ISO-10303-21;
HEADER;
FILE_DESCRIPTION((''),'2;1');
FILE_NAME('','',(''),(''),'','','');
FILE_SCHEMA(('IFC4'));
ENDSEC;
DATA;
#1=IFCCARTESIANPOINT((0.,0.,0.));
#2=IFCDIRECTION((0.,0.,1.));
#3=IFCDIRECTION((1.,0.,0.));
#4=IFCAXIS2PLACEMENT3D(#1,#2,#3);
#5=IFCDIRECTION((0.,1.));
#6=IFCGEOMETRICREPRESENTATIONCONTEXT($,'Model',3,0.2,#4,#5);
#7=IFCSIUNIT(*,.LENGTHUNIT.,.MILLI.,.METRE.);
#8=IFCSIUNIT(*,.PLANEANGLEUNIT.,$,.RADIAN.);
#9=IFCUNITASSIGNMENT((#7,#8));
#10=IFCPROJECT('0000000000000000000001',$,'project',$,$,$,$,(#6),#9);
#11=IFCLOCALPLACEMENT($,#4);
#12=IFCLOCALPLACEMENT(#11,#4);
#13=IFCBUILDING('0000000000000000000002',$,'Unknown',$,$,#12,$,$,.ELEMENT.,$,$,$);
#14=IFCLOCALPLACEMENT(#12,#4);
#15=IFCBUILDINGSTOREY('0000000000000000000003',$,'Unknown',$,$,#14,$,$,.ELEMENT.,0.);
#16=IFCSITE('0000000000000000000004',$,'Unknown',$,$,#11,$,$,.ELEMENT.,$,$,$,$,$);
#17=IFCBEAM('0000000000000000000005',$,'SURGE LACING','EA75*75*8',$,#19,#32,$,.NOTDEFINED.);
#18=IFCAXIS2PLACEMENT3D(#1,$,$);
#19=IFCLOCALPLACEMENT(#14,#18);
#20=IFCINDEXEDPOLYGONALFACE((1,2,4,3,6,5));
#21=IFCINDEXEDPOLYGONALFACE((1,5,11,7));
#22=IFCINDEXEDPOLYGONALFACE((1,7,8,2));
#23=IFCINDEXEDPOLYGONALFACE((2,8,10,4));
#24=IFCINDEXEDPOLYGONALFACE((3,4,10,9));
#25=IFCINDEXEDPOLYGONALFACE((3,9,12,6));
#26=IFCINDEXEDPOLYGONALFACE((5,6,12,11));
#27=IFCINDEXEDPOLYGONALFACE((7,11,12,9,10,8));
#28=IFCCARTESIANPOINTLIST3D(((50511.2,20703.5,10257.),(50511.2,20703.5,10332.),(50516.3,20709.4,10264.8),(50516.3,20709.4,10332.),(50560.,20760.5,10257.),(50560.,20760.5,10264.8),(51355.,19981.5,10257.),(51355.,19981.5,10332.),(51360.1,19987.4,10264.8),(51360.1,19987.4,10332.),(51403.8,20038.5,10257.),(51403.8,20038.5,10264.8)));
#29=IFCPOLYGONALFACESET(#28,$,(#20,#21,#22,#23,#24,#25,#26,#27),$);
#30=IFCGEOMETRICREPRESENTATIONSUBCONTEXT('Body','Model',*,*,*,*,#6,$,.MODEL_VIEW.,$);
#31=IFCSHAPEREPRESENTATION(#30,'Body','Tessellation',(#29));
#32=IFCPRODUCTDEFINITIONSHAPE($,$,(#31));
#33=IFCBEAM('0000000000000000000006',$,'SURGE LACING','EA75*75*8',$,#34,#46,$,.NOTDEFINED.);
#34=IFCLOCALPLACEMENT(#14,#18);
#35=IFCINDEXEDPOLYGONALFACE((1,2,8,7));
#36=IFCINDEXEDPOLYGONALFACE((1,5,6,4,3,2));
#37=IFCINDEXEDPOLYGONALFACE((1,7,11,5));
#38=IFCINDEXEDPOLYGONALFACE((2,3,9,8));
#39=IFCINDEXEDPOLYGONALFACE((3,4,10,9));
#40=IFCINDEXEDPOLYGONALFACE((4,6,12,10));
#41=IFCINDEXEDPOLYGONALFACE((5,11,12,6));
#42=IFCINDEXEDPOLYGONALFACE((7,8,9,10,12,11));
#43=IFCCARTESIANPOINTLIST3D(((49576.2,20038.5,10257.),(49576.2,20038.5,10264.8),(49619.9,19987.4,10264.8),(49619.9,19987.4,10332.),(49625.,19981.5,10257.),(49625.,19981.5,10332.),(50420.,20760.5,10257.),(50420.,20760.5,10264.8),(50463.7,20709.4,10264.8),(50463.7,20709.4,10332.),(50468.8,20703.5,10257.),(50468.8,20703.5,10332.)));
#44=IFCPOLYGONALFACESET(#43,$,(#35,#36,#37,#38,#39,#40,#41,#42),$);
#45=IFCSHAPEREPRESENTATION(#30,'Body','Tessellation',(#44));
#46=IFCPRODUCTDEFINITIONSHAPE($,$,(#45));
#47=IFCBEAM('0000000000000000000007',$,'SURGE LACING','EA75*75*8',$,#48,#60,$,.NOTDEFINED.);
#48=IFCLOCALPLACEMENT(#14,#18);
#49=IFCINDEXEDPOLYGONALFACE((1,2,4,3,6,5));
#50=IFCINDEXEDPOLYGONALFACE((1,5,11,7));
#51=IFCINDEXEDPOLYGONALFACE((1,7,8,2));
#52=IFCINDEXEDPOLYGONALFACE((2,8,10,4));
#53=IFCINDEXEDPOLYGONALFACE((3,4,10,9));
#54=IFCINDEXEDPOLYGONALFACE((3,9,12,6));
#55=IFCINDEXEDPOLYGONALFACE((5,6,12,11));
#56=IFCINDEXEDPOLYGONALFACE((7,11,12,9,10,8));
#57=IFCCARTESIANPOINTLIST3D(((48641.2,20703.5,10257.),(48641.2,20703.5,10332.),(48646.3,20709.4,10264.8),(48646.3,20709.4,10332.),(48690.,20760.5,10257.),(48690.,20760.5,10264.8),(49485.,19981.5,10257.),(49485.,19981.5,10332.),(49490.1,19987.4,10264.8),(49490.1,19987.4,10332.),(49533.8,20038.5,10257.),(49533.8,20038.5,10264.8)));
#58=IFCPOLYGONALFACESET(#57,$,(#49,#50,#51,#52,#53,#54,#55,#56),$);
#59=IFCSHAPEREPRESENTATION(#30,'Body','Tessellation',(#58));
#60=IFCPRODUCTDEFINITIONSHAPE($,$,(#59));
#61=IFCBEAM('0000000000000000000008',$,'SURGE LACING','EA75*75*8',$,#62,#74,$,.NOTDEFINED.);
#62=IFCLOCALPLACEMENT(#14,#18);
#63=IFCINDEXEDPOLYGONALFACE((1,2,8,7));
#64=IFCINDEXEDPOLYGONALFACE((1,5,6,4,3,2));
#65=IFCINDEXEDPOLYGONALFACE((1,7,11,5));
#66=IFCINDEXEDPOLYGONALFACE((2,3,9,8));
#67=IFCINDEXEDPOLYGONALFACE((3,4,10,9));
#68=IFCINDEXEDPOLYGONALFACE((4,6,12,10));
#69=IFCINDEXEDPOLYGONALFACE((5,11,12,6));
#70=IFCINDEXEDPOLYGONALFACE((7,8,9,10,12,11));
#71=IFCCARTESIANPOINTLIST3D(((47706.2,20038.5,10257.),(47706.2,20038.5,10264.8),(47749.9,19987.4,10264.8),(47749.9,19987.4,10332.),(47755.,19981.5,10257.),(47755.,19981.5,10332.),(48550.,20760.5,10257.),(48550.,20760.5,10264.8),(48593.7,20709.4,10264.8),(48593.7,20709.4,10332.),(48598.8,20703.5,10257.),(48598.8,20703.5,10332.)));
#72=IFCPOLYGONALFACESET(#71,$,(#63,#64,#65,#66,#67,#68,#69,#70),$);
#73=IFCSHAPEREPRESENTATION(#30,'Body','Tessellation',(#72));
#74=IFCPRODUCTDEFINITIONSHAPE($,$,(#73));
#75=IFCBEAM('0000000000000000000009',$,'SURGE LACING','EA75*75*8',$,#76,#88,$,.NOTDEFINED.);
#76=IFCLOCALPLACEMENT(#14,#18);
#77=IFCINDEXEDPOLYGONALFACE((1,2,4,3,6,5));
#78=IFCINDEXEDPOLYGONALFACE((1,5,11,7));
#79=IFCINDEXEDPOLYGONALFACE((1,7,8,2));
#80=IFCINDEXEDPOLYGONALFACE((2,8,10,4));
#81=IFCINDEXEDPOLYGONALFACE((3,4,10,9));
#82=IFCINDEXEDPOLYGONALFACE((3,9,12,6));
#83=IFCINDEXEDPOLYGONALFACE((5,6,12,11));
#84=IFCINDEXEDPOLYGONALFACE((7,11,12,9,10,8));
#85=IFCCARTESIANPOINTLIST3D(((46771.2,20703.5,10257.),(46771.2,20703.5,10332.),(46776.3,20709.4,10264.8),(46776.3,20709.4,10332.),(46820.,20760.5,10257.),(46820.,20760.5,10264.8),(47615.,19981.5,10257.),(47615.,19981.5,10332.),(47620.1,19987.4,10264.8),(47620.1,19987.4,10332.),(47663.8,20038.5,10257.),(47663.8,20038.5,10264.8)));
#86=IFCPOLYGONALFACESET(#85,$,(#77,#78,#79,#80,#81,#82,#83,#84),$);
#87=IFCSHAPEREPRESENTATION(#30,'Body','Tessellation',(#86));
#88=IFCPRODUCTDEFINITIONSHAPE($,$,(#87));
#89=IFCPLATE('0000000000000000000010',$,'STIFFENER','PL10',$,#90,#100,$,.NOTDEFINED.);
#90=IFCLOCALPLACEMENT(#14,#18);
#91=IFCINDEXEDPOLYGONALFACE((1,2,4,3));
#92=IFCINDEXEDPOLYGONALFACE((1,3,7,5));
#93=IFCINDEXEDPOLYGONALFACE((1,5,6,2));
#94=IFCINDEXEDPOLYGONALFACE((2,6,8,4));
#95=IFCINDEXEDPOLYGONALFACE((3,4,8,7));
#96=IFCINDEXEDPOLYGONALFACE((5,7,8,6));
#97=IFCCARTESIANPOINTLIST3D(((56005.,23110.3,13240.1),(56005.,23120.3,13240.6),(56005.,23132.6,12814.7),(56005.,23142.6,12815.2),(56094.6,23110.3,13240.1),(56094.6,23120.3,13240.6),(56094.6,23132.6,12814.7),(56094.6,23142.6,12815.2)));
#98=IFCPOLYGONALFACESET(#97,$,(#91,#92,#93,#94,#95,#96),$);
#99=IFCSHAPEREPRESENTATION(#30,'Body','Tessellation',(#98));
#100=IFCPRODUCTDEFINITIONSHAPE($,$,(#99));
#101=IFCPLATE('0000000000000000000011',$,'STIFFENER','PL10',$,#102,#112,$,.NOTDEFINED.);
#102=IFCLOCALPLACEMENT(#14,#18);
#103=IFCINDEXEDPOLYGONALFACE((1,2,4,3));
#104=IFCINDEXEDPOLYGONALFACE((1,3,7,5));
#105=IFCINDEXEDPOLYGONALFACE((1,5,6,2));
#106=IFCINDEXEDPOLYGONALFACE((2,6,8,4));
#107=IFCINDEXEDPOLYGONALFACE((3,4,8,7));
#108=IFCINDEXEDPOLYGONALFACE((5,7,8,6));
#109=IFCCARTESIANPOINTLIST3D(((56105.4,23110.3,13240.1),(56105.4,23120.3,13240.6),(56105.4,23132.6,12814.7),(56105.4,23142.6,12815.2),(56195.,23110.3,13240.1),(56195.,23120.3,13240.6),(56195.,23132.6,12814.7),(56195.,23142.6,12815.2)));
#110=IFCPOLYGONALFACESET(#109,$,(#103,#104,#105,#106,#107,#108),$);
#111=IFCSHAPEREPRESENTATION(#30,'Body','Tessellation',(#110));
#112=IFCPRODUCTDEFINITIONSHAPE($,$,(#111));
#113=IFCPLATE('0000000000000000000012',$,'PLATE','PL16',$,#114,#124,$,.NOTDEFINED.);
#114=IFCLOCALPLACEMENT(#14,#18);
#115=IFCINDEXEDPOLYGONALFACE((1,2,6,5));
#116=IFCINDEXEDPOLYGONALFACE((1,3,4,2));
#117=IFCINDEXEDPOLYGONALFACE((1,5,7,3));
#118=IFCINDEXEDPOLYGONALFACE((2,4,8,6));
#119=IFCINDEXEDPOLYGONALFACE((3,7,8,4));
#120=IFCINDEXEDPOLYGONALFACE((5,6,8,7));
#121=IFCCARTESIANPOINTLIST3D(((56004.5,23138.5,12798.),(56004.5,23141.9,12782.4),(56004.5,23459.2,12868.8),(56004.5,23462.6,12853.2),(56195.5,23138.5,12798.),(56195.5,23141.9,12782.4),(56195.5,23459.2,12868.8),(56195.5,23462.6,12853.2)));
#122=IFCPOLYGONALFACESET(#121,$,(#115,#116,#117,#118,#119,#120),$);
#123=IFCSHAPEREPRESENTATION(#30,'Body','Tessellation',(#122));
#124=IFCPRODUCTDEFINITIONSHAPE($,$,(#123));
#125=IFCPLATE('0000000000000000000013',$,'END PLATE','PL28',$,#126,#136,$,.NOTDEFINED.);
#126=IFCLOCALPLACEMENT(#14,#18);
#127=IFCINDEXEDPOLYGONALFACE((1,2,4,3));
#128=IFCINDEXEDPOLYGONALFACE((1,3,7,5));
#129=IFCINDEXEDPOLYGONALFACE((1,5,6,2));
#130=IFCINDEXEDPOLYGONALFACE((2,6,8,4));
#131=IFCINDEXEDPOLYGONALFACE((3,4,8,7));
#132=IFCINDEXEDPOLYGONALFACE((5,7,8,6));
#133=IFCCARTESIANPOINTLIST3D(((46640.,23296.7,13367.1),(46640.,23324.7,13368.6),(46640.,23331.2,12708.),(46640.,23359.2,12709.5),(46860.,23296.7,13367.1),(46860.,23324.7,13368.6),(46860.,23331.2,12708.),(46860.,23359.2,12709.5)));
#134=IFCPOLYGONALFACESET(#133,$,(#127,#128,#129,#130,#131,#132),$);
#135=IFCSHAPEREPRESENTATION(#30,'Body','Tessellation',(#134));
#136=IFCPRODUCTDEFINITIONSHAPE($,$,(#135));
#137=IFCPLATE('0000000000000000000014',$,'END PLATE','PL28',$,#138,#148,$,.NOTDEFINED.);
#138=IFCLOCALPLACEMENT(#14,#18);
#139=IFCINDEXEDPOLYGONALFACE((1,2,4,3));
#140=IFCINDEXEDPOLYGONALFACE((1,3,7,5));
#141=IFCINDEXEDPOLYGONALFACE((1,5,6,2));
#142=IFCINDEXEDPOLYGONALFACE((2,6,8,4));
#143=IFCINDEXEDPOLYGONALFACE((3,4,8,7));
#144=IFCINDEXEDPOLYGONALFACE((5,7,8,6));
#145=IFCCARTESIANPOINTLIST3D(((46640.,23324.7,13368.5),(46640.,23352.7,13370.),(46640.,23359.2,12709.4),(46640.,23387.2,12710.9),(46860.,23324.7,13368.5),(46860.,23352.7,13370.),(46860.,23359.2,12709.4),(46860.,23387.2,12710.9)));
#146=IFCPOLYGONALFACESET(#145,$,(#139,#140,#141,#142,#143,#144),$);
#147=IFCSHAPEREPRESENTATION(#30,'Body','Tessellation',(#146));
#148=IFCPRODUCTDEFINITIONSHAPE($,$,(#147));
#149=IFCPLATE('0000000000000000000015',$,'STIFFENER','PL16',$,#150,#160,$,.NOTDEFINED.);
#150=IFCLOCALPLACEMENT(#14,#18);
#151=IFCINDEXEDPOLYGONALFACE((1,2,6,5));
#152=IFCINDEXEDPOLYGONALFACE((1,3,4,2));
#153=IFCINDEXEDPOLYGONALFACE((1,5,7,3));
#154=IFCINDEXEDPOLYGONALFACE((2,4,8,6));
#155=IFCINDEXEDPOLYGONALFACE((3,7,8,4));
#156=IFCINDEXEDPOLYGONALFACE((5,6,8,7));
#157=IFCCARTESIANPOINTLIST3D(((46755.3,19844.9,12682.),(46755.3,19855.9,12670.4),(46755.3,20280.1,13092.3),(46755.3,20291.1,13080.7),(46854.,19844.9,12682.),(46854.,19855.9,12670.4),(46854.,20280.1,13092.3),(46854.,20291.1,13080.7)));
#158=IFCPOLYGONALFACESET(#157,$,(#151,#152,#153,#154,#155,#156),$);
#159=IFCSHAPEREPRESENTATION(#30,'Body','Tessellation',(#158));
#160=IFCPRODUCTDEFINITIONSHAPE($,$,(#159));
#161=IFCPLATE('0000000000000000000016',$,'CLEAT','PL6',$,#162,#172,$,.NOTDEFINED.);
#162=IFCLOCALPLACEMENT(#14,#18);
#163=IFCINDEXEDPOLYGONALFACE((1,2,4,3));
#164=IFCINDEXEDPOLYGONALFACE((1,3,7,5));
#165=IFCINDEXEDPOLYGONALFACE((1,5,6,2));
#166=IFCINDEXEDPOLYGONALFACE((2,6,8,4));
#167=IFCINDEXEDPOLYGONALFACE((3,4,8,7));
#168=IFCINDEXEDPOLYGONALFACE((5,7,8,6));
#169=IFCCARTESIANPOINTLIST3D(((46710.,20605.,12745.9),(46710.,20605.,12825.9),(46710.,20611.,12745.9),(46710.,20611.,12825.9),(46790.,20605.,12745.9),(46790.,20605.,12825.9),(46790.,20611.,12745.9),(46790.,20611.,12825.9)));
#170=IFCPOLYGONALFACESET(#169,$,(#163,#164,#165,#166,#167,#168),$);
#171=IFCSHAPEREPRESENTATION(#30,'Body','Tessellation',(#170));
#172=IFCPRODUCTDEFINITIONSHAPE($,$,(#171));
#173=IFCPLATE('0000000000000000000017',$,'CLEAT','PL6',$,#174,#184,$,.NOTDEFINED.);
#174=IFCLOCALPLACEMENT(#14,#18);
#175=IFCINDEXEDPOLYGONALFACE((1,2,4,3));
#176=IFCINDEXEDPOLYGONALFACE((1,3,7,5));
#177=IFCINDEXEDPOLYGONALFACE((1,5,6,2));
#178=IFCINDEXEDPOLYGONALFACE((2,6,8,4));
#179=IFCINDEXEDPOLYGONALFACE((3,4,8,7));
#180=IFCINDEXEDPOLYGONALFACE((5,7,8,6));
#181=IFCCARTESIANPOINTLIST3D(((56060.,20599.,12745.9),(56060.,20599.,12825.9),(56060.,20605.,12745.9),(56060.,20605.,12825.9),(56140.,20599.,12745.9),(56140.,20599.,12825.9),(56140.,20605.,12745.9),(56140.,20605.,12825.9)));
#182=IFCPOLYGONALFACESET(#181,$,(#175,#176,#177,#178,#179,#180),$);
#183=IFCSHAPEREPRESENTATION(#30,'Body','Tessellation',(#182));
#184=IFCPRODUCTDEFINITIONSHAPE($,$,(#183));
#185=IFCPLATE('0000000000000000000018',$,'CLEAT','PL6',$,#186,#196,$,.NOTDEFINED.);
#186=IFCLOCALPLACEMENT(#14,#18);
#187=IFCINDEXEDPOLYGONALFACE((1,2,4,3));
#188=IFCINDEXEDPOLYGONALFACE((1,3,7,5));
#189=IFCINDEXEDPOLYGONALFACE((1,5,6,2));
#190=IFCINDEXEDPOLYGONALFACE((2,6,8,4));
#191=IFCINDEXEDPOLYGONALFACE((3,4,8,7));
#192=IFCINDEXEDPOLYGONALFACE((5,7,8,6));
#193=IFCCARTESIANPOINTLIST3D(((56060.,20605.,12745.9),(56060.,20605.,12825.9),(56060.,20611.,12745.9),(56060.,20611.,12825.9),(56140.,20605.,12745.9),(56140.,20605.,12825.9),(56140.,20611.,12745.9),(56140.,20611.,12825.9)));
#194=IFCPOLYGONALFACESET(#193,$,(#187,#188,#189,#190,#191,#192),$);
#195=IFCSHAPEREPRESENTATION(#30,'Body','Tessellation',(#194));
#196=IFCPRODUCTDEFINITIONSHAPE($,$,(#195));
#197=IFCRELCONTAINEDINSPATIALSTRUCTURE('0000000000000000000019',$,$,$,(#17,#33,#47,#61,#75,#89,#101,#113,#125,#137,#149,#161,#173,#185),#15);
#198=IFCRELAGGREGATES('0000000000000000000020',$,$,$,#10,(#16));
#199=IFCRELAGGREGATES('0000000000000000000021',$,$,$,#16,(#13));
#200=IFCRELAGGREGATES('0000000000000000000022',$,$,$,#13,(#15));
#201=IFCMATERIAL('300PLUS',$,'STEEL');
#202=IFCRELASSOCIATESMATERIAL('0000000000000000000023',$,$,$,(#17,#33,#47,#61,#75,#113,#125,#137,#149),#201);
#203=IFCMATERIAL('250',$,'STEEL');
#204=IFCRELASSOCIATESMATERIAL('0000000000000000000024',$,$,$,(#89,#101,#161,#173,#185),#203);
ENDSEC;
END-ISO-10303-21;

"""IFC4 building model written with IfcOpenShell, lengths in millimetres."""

from ifc_helpers import new_model, si_unit, direction, frame, origin_with_axes, place, context, subcontext, project, spatial, line, indexed_curve, outline, extrude, material, element, save


model = new_model("IFC4")

# Units and contexts
model_context = context("Model", 3, precision=0.2, world=origin_with_axes(), true_north=direction((0.0, 1.0)))
body_context = subcontext(model_context, "Body", "Model", "MODEL_VIEW")
ifc_project = project(units=[si_unit("LENGTHUNIT", "METRE", prefix="MILLI"), si_unit("PLANEANGLEUNIT", "RADIAN")], contexts=[model_context])

# Site, building, storey
site_placement = place(None, origin_with_axes())
site = spatial("IfcSite", under=ifc_project, at=site_placement, Name="Unknown", CompositionType="ELEMENT")
building_placement = place(site_placement, origin_with_axes())
building = spatial("IfcBuilding", under=site, at=building_placement, Name="Unknown", CompositionType="ELEMENT")
storey_placement = place(building_placement, origin_with_axes())
storey = spatial("IfcBuildingStorey", under=building, at=storey_placement, Name="Unknown", CompositionType="ELEMENT", Elevation=0.0)

# Beams
ifc_material_1 = material(Name="300PLUS", Category="STEEL")
for number, where, z_axis, x_axis, name in (
    (1, (50535.6, 20732.0, 10294.5), (0.0, 0.0, 1.0), (0.759816, -0.650139, 0.0), "SURGE LACING"),
    (2, (49600.6, 20010.0, 10294.5), (0.0, 0.0, 1.0), (0.759816, 0.650139, 0.0), "SURGE LACING"),
    (3, (48665.6, 20732.0, 10294.5), (0.0, 0.0, 1.0), (0.759816, -0.650139, 0.0), "SURGE LACING"),
    (4, (47730.6, 20010.0, 10294.5), (0.0, 0.0, 1.0), (0.759816, 0.650139, 0.0), "SURGE LACING"),
    (5, (46795.6, 20732.0, 10294.5), (0.0, 0.0, 1.0), (0.759816, -0.650139, 0.0), "SURGE LACING"),
):
    element("IfcBeam", number, at=place(storey_placement, frame(where, z_axis=z_axis, x_axis=x_axis)), inside=storey, material=ifc_material_1, Name=name, Description="EA75*75*8", PredefinedType="NOTDEFINED", context=body_context, shape_type="SolidModel", body=[
        extrude(outline(indexed_curve([(-37.5, -37.5), (37.5, -37.5), (37.5, -29.7), (-29.7, -29.7), (-29.7, 37.5), (-37.5, 37.5)], segments=[line(1, 2, 3, 4, 5, 6, 1)])), frame((0.0, 0.0, 0.0), z_axis=(-1.0, 0.0, 0.0), x_axis=(0.0, 0.0, 1.0)), (0.0, 0.0, -1.0), 1110.5),
    ])

# Plates
ifc_material_2 = material(Name="250", Category="STEEL")
for number, where, z_axis, x_axis, name in (
    (6, (56005.0, 23137.6, 12815.0), (0.0, 0.998629, 0.052349), (0.0, -0.052349, 0.998629), "STIFFENER"),
    (7, (56105.4, 23137.6, 12815.0), (0.0, 0.998629, 0.052349), (0.0, -0.052349, 0.998629), "STIFFENER"),
):
    element("IfcPlate", number, at=place(storey_placement, frame(where, z_axis=z_axis, x_axis=x_axis)), inside=storey, material=ifc_material_2, Name=name, Description="PL10", PredefinedType="NOTDEFINED", context=body_context, shape_type="SolidModel", body=[
        extrude(outline(indexed_curve([(0.0, 0.0), (426.0, 0.0), (426.0, 89.6), (0.0, 89.6)], segments=[line(1, 2, 3, 4, 1)])), frame((0.0, 0.0, 5.0), z_axis=(0.0, 0.0, 1.0), x_axis=(1.0, 0.0, 0.0)), (0.0, 0.0, -1.0), 10.0),
    ])
plate_1_placement = place(storey_placement, frame((56004.5, 23460.9, 12861.0), z_axis=(0.0, -0.215576, 0.976487), x_axis=(0.0, -0.976487, -0.215576)))
element("IfcPlate", 8, at=plate_1_placement, inside=storey, material=ifc_material_1, Name="PLATE", Description="PL16", PredefinedType="NOTDEFINED", context=body_context, shape_type="SolidModel", body=[
    extrude(outline(indexed_curve([(0.0, 0.0), (328.4, 0.0), (328.4, 191.0), (0.0, 191.0)], segments=[line(1, 2, 3, 4, 1)])), frame((0.0, 0.0, 8.0), z_axis=(0.0, 0.0, 1.0), x_axis=(1.0, 0.0, 0.0)), (0.0, 0.0, -1.0), 16.0),
])
for number, where, z_axis, x_axis, name in (
    (9, (46860.0, 23345.2, 12708.7), (0.0, 0.998633, 0.052273), (-1.0, 0.0, 0.0), "END PLATE"),
    (10, (46860.0, 23373.2, 12710.1), (0.0, 0.998633, 0.052273), (-1.0, 0.0, 0.0), "END PLATE"),
):
    element("IfcPlate", number, at=place(storey_placement, frame(where, z_axis=z_axis, x_axis=x_axis)), inside=storey, material=ifc_material_1, Name=name, Description="PL28", PredefinedType="NOTDEFINED", context=body_context, shape_type="SolidModel", body=[
        extrude(outline(indexed_curve([(0.0, 0.0), (220.0, 0.0), (220.0, 660.0), (0.0, 660.0)], segments=[line(1, 2, 3, 4, 1)])), frame((0.0, 0.0, 14.0), z_axis=(0.0, 0.0, 1.0), x_axis=(1.0, 0.0, 0.0)), (0.0, 0.0, -1.0), 28.0),
    ])
plate_2_placement = place(storey_placement, frame((46854.0, 19850.4, 12676.2), z_axis=(0.0, -0.685985, 0.727616), x_axis=(0.0, 0.727616, 0.685985)))
element("IfcPlate", 11, at=plate_2_placement, inside=storey, material=ifc_material_1, Name="STIFFENER", Description="PL16", PredefinedType="NOTDEFINED", context=body_context, shape_type="SolidModel", body=[
    extrude(outline(indexed_curve([(0.0, 0.0), (598.1, 0.0), (598.1, 98.7), (0.0, 98.7)], segments=[line(1, 2, 3, 4, 1)])), frame((0.0, 0.0, 8.0), z_axis=(0.0, 0.0, 1.0), x_axis=(1.0, 0.0, 0.0)), (0.0, 0.0, -1.0), 16.0),
])
for number, where, z_axis, x_axis, name in (
    (12, (46790.0, 20608.0, 12745.9), (0.0, 1.0, 0.0), (-1.0, 0.0, 0.0), "CLEAT"),
    (13, (56060.0, 20602.0, 12745.9), (0.0, -1.0, 0.0), (1.0, 0.0, 0.0), "CLEAT"),
    (14, (56140.0, 20608.0, 12745.9), (0.0, 1.0, 0.0), (-1.0, 0.0, 0.0), "CLEAT"),
):
    element("IfcPlate", number, at=place(storey_placement, frame(where, z_axis=z_axis, x_axis=x_axis)), inside=storey, material=ifc_material_2, Name=name, Description="PL6", PredefinedType="NOTDEFINED", context=body_context, shape_type="SolidModel", body=[
        extrude(outline(indexed_curve([(0.0, 0.0), (80.0, 0.0), (80.0, 80.0), (0.0, 80.0)], segments=[line(1, 2, 3, 4, 1)])), frame((0.0, 0.0, 3.0), z_axis=(0.0, 0.0, 1.0), x_axis=(1.0, 0.0, 0.0)), (0.0, 0.0, -1.0), 6.0),
    ])

save(model, "model.ifc")
